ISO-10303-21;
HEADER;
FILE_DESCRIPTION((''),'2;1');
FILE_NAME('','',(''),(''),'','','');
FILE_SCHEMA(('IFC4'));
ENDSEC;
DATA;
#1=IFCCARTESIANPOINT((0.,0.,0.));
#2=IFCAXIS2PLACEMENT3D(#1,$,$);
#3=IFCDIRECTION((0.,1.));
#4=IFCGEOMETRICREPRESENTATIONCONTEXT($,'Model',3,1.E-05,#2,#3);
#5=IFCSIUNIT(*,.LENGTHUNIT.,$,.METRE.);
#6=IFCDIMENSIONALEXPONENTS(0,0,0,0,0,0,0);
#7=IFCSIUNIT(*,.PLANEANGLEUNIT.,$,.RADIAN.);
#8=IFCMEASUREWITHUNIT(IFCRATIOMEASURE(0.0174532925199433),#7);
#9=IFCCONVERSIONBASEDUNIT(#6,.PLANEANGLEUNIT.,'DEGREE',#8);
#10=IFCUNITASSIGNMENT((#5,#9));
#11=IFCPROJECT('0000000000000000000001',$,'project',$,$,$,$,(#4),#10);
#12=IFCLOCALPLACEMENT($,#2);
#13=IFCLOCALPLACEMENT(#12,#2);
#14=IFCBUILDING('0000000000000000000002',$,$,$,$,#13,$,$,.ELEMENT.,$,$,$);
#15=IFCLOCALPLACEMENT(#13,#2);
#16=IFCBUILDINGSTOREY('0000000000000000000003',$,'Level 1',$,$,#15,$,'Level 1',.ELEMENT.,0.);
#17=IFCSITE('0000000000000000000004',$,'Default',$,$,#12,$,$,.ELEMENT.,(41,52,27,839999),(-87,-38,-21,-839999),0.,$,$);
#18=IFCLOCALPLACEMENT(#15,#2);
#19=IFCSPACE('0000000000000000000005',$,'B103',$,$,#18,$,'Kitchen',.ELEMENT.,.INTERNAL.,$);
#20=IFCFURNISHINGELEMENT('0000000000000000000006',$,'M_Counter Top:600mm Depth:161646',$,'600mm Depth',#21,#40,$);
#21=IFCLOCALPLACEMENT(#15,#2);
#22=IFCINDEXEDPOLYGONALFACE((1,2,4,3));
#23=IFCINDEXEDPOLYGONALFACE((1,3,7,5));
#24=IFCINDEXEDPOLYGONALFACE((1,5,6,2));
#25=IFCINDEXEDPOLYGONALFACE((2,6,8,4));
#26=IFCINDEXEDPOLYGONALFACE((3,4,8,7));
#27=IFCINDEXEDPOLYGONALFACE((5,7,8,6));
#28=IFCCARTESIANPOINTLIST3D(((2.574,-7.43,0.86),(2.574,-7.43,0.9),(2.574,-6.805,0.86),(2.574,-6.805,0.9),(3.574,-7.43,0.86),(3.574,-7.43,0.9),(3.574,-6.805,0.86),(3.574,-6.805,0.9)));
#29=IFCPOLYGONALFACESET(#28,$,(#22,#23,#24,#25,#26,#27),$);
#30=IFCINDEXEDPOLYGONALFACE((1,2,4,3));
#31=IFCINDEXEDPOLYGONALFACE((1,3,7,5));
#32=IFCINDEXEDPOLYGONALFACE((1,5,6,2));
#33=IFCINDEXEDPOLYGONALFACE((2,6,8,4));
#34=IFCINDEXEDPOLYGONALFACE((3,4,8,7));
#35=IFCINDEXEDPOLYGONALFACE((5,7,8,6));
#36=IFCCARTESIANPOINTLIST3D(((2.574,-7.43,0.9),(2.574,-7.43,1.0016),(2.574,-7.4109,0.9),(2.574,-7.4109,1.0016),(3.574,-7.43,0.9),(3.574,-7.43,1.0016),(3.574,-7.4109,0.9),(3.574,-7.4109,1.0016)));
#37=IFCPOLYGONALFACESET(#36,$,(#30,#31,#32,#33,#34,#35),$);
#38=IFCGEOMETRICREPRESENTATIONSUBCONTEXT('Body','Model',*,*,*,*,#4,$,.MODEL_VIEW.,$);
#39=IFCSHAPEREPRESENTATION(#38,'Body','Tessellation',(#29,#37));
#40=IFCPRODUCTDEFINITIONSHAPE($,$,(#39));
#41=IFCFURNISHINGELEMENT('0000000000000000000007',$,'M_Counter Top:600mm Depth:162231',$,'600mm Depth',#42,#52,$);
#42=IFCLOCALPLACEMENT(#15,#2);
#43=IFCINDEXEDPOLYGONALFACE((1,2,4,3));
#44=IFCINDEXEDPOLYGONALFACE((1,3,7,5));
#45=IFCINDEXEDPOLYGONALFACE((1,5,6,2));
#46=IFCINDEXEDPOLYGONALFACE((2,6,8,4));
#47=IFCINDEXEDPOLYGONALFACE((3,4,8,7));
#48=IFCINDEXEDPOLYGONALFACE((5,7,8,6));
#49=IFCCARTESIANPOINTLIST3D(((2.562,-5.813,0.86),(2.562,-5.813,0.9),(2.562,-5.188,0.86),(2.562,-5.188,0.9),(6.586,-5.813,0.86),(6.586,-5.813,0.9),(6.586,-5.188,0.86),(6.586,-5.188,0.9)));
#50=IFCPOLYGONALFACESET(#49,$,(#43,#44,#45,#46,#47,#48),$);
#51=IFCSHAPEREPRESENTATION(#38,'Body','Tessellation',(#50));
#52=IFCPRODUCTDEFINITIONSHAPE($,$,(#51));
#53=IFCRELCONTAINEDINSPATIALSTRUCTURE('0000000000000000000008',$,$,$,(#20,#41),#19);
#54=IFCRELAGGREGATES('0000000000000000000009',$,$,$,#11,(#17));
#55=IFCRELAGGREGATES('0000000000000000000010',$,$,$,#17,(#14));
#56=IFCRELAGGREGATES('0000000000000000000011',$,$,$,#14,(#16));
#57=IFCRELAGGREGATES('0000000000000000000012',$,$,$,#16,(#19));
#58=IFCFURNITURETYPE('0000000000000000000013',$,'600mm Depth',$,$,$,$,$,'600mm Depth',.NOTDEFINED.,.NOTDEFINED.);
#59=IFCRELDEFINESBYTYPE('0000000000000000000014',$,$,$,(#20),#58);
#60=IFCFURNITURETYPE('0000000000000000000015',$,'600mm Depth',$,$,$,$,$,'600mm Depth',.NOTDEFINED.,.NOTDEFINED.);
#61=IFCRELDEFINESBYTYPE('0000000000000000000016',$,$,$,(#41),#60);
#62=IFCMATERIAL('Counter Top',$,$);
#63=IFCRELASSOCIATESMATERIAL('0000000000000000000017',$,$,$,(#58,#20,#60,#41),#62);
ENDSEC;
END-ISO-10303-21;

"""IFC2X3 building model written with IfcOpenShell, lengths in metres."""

from ifc_helpers import new_model, entity, si_unit, converted_unit, direction, frame, frame_2d, origin, place, context, subcontext, project, spatial, rectangle, extrude, source, transform, mapped, material, type_object, type_shapes, element, save


model = new_model("IFC2X3")

# Units and contexts
model_context = context("Model", 3, precision=1e-05, world=origin(), true_north=direction((0.0, 1.0)))
body_context = subcontext(model_context, "Body", "Model", "MODEL_VIEW")
ifc_project = project(units=[si_unit("LENGTHUNIT", "METRE"), converted_unit("PLANEANGLEUNIT", "DEGREE", entity("IfcRatioMeasure", 0.0174532925199433), si_unit("PLANEANGLEUNIT", "RADIAN"), dimensions=[0, 0, 0, 0, 0, 0, 0])], contexts=[model_context])

# Site, building, storey
site_placement = place(None, origin())
site = spatial("IfcSite", under=ifc_project, at=site_placement, Name="Default", CompositionType="ELEMENT", RefLatitude=(41, 52, 27, 839999), RefLongitude=(-87, -38, -21, -839999), RefElevation=0.0)
building_placement = place(site_placement, origin())
building = spatial("IfcBuilding", under=site, at=building_placement, CompositionType="ELEMENT")
storey_placement = place(building_placement, origin())
storey = spatial("IfcBuildingStorey", under=building, at=storey_placement, Name="Level 1", LongName="Level 1", CompositionType="ELEMENT", Elevation=0.0)

# Shared definitions
space_1_placement = place(storey_placement, origin())
space_1 = spatial("IfcSpace", under=storey, at=space_1_placement, Name="B103", LongName="Kitchen", CompositionType="ELEMENT", InteriorOrExteriorSpace="INTERNAL")

# Shared definitions
ifc_material_1 = material(Name="Counter Top")

# Furnishing elements
furniture_type_1 = type_object("IfcFurnitureType", Name="600mm Depth", ElementType="600mm Depth", AssemblyPlace="NOTDEFINED", material=ifc_material_1)
shared_shape_1 = source(origin(), body_context, "Body", "SweptSolid", [
    extrude(rectangle(XDim=1.0, YDim=0.625, at=frame_2d((0.0, 0.0), x_axis=(1.0, 0.0))), frame((-0.7005, -0.3125, 0.86), z_axis=(0.0, 0.0, 1.0), x_axis=(-1.0, 0.0, 0.0)), (0.0, 0.0, 1.0), 0.04),
    extrude(rectangle(XDim=0.0191, YDim=1.0, at=frame_2d((0.0, 0.0), x_axis=(1.0, 0.0))), frame((-0.7005, -0.0095, 0.9), z_axis=(0.0, 0.0, 1.0), x_axis=(0.0, -1.0, 0.0)), (0.0, 0.0, 1.0), 0.1016),
])
type_shapes(furniture_type_1, [shared_shape_1])
furnishing_1_placement = place(space_1_placement, frame((2.3735, -7.43, 0.0), z_axis=(0.0, 0.0, 1.0), x_axis=(-1.0, 0.0, 0.0)))
element("IfcFurnishingElement", 1, at=furnishing_1_placement, inside=space_1, type_object=furniture_type_1, material=ifc_material_1, Name="M_Counter Top:600mm Depth:161646", ObjectType="600mm Depth", context=body_context, shape_type="MappedRepresentation", body=[
    mapped(shared_shape_1, transform((0.0, 0.0, 0.0), scale=1.0)),
])
furniture_type_2 = type_object("IfcFurnitureType", Name="600mm Depth", ElementType="600mm Depth", AssemblyPlace="NOTDEFINED", material=ifc_material_1)
shared_shape_2 = source(origin(), body_context, "Body", "SweptSolid", [
    extrude(rectangle(XDim=4.024, YDim=0.625, at=frame_2d((0.0, 0.0), x_axis=(1.0, 0.0))), frame((0.8115, -0.3125, 0.86), z_axis=(0.0, 0.0, 1.0), x_axis=(-1.0, 0.0, 0.0)), (0.0, 0.0, 1.0), 0.04),
])
type_shapes(furniture_type_2, [shared_shape_2])
furnishing_2_placement = place(space_1_placement, frame((3.7625, -5.188, 0.0)))
element("IfcFurnishingElement", 2, at=furnishing_2_placement, inside=space_1, type_object=furniture_type_2, material=ifc_material_1, Name="M_Counter Top:600mm Depth:162231", ObjectType="600mm Depth", context=body_context, shape_type="MappedRepresentation", body=[
    mapped(shared_shape_2, transform((0.0, 0.0, 0.0), scale=1.0)),
])

save(model, "model.ifc")
